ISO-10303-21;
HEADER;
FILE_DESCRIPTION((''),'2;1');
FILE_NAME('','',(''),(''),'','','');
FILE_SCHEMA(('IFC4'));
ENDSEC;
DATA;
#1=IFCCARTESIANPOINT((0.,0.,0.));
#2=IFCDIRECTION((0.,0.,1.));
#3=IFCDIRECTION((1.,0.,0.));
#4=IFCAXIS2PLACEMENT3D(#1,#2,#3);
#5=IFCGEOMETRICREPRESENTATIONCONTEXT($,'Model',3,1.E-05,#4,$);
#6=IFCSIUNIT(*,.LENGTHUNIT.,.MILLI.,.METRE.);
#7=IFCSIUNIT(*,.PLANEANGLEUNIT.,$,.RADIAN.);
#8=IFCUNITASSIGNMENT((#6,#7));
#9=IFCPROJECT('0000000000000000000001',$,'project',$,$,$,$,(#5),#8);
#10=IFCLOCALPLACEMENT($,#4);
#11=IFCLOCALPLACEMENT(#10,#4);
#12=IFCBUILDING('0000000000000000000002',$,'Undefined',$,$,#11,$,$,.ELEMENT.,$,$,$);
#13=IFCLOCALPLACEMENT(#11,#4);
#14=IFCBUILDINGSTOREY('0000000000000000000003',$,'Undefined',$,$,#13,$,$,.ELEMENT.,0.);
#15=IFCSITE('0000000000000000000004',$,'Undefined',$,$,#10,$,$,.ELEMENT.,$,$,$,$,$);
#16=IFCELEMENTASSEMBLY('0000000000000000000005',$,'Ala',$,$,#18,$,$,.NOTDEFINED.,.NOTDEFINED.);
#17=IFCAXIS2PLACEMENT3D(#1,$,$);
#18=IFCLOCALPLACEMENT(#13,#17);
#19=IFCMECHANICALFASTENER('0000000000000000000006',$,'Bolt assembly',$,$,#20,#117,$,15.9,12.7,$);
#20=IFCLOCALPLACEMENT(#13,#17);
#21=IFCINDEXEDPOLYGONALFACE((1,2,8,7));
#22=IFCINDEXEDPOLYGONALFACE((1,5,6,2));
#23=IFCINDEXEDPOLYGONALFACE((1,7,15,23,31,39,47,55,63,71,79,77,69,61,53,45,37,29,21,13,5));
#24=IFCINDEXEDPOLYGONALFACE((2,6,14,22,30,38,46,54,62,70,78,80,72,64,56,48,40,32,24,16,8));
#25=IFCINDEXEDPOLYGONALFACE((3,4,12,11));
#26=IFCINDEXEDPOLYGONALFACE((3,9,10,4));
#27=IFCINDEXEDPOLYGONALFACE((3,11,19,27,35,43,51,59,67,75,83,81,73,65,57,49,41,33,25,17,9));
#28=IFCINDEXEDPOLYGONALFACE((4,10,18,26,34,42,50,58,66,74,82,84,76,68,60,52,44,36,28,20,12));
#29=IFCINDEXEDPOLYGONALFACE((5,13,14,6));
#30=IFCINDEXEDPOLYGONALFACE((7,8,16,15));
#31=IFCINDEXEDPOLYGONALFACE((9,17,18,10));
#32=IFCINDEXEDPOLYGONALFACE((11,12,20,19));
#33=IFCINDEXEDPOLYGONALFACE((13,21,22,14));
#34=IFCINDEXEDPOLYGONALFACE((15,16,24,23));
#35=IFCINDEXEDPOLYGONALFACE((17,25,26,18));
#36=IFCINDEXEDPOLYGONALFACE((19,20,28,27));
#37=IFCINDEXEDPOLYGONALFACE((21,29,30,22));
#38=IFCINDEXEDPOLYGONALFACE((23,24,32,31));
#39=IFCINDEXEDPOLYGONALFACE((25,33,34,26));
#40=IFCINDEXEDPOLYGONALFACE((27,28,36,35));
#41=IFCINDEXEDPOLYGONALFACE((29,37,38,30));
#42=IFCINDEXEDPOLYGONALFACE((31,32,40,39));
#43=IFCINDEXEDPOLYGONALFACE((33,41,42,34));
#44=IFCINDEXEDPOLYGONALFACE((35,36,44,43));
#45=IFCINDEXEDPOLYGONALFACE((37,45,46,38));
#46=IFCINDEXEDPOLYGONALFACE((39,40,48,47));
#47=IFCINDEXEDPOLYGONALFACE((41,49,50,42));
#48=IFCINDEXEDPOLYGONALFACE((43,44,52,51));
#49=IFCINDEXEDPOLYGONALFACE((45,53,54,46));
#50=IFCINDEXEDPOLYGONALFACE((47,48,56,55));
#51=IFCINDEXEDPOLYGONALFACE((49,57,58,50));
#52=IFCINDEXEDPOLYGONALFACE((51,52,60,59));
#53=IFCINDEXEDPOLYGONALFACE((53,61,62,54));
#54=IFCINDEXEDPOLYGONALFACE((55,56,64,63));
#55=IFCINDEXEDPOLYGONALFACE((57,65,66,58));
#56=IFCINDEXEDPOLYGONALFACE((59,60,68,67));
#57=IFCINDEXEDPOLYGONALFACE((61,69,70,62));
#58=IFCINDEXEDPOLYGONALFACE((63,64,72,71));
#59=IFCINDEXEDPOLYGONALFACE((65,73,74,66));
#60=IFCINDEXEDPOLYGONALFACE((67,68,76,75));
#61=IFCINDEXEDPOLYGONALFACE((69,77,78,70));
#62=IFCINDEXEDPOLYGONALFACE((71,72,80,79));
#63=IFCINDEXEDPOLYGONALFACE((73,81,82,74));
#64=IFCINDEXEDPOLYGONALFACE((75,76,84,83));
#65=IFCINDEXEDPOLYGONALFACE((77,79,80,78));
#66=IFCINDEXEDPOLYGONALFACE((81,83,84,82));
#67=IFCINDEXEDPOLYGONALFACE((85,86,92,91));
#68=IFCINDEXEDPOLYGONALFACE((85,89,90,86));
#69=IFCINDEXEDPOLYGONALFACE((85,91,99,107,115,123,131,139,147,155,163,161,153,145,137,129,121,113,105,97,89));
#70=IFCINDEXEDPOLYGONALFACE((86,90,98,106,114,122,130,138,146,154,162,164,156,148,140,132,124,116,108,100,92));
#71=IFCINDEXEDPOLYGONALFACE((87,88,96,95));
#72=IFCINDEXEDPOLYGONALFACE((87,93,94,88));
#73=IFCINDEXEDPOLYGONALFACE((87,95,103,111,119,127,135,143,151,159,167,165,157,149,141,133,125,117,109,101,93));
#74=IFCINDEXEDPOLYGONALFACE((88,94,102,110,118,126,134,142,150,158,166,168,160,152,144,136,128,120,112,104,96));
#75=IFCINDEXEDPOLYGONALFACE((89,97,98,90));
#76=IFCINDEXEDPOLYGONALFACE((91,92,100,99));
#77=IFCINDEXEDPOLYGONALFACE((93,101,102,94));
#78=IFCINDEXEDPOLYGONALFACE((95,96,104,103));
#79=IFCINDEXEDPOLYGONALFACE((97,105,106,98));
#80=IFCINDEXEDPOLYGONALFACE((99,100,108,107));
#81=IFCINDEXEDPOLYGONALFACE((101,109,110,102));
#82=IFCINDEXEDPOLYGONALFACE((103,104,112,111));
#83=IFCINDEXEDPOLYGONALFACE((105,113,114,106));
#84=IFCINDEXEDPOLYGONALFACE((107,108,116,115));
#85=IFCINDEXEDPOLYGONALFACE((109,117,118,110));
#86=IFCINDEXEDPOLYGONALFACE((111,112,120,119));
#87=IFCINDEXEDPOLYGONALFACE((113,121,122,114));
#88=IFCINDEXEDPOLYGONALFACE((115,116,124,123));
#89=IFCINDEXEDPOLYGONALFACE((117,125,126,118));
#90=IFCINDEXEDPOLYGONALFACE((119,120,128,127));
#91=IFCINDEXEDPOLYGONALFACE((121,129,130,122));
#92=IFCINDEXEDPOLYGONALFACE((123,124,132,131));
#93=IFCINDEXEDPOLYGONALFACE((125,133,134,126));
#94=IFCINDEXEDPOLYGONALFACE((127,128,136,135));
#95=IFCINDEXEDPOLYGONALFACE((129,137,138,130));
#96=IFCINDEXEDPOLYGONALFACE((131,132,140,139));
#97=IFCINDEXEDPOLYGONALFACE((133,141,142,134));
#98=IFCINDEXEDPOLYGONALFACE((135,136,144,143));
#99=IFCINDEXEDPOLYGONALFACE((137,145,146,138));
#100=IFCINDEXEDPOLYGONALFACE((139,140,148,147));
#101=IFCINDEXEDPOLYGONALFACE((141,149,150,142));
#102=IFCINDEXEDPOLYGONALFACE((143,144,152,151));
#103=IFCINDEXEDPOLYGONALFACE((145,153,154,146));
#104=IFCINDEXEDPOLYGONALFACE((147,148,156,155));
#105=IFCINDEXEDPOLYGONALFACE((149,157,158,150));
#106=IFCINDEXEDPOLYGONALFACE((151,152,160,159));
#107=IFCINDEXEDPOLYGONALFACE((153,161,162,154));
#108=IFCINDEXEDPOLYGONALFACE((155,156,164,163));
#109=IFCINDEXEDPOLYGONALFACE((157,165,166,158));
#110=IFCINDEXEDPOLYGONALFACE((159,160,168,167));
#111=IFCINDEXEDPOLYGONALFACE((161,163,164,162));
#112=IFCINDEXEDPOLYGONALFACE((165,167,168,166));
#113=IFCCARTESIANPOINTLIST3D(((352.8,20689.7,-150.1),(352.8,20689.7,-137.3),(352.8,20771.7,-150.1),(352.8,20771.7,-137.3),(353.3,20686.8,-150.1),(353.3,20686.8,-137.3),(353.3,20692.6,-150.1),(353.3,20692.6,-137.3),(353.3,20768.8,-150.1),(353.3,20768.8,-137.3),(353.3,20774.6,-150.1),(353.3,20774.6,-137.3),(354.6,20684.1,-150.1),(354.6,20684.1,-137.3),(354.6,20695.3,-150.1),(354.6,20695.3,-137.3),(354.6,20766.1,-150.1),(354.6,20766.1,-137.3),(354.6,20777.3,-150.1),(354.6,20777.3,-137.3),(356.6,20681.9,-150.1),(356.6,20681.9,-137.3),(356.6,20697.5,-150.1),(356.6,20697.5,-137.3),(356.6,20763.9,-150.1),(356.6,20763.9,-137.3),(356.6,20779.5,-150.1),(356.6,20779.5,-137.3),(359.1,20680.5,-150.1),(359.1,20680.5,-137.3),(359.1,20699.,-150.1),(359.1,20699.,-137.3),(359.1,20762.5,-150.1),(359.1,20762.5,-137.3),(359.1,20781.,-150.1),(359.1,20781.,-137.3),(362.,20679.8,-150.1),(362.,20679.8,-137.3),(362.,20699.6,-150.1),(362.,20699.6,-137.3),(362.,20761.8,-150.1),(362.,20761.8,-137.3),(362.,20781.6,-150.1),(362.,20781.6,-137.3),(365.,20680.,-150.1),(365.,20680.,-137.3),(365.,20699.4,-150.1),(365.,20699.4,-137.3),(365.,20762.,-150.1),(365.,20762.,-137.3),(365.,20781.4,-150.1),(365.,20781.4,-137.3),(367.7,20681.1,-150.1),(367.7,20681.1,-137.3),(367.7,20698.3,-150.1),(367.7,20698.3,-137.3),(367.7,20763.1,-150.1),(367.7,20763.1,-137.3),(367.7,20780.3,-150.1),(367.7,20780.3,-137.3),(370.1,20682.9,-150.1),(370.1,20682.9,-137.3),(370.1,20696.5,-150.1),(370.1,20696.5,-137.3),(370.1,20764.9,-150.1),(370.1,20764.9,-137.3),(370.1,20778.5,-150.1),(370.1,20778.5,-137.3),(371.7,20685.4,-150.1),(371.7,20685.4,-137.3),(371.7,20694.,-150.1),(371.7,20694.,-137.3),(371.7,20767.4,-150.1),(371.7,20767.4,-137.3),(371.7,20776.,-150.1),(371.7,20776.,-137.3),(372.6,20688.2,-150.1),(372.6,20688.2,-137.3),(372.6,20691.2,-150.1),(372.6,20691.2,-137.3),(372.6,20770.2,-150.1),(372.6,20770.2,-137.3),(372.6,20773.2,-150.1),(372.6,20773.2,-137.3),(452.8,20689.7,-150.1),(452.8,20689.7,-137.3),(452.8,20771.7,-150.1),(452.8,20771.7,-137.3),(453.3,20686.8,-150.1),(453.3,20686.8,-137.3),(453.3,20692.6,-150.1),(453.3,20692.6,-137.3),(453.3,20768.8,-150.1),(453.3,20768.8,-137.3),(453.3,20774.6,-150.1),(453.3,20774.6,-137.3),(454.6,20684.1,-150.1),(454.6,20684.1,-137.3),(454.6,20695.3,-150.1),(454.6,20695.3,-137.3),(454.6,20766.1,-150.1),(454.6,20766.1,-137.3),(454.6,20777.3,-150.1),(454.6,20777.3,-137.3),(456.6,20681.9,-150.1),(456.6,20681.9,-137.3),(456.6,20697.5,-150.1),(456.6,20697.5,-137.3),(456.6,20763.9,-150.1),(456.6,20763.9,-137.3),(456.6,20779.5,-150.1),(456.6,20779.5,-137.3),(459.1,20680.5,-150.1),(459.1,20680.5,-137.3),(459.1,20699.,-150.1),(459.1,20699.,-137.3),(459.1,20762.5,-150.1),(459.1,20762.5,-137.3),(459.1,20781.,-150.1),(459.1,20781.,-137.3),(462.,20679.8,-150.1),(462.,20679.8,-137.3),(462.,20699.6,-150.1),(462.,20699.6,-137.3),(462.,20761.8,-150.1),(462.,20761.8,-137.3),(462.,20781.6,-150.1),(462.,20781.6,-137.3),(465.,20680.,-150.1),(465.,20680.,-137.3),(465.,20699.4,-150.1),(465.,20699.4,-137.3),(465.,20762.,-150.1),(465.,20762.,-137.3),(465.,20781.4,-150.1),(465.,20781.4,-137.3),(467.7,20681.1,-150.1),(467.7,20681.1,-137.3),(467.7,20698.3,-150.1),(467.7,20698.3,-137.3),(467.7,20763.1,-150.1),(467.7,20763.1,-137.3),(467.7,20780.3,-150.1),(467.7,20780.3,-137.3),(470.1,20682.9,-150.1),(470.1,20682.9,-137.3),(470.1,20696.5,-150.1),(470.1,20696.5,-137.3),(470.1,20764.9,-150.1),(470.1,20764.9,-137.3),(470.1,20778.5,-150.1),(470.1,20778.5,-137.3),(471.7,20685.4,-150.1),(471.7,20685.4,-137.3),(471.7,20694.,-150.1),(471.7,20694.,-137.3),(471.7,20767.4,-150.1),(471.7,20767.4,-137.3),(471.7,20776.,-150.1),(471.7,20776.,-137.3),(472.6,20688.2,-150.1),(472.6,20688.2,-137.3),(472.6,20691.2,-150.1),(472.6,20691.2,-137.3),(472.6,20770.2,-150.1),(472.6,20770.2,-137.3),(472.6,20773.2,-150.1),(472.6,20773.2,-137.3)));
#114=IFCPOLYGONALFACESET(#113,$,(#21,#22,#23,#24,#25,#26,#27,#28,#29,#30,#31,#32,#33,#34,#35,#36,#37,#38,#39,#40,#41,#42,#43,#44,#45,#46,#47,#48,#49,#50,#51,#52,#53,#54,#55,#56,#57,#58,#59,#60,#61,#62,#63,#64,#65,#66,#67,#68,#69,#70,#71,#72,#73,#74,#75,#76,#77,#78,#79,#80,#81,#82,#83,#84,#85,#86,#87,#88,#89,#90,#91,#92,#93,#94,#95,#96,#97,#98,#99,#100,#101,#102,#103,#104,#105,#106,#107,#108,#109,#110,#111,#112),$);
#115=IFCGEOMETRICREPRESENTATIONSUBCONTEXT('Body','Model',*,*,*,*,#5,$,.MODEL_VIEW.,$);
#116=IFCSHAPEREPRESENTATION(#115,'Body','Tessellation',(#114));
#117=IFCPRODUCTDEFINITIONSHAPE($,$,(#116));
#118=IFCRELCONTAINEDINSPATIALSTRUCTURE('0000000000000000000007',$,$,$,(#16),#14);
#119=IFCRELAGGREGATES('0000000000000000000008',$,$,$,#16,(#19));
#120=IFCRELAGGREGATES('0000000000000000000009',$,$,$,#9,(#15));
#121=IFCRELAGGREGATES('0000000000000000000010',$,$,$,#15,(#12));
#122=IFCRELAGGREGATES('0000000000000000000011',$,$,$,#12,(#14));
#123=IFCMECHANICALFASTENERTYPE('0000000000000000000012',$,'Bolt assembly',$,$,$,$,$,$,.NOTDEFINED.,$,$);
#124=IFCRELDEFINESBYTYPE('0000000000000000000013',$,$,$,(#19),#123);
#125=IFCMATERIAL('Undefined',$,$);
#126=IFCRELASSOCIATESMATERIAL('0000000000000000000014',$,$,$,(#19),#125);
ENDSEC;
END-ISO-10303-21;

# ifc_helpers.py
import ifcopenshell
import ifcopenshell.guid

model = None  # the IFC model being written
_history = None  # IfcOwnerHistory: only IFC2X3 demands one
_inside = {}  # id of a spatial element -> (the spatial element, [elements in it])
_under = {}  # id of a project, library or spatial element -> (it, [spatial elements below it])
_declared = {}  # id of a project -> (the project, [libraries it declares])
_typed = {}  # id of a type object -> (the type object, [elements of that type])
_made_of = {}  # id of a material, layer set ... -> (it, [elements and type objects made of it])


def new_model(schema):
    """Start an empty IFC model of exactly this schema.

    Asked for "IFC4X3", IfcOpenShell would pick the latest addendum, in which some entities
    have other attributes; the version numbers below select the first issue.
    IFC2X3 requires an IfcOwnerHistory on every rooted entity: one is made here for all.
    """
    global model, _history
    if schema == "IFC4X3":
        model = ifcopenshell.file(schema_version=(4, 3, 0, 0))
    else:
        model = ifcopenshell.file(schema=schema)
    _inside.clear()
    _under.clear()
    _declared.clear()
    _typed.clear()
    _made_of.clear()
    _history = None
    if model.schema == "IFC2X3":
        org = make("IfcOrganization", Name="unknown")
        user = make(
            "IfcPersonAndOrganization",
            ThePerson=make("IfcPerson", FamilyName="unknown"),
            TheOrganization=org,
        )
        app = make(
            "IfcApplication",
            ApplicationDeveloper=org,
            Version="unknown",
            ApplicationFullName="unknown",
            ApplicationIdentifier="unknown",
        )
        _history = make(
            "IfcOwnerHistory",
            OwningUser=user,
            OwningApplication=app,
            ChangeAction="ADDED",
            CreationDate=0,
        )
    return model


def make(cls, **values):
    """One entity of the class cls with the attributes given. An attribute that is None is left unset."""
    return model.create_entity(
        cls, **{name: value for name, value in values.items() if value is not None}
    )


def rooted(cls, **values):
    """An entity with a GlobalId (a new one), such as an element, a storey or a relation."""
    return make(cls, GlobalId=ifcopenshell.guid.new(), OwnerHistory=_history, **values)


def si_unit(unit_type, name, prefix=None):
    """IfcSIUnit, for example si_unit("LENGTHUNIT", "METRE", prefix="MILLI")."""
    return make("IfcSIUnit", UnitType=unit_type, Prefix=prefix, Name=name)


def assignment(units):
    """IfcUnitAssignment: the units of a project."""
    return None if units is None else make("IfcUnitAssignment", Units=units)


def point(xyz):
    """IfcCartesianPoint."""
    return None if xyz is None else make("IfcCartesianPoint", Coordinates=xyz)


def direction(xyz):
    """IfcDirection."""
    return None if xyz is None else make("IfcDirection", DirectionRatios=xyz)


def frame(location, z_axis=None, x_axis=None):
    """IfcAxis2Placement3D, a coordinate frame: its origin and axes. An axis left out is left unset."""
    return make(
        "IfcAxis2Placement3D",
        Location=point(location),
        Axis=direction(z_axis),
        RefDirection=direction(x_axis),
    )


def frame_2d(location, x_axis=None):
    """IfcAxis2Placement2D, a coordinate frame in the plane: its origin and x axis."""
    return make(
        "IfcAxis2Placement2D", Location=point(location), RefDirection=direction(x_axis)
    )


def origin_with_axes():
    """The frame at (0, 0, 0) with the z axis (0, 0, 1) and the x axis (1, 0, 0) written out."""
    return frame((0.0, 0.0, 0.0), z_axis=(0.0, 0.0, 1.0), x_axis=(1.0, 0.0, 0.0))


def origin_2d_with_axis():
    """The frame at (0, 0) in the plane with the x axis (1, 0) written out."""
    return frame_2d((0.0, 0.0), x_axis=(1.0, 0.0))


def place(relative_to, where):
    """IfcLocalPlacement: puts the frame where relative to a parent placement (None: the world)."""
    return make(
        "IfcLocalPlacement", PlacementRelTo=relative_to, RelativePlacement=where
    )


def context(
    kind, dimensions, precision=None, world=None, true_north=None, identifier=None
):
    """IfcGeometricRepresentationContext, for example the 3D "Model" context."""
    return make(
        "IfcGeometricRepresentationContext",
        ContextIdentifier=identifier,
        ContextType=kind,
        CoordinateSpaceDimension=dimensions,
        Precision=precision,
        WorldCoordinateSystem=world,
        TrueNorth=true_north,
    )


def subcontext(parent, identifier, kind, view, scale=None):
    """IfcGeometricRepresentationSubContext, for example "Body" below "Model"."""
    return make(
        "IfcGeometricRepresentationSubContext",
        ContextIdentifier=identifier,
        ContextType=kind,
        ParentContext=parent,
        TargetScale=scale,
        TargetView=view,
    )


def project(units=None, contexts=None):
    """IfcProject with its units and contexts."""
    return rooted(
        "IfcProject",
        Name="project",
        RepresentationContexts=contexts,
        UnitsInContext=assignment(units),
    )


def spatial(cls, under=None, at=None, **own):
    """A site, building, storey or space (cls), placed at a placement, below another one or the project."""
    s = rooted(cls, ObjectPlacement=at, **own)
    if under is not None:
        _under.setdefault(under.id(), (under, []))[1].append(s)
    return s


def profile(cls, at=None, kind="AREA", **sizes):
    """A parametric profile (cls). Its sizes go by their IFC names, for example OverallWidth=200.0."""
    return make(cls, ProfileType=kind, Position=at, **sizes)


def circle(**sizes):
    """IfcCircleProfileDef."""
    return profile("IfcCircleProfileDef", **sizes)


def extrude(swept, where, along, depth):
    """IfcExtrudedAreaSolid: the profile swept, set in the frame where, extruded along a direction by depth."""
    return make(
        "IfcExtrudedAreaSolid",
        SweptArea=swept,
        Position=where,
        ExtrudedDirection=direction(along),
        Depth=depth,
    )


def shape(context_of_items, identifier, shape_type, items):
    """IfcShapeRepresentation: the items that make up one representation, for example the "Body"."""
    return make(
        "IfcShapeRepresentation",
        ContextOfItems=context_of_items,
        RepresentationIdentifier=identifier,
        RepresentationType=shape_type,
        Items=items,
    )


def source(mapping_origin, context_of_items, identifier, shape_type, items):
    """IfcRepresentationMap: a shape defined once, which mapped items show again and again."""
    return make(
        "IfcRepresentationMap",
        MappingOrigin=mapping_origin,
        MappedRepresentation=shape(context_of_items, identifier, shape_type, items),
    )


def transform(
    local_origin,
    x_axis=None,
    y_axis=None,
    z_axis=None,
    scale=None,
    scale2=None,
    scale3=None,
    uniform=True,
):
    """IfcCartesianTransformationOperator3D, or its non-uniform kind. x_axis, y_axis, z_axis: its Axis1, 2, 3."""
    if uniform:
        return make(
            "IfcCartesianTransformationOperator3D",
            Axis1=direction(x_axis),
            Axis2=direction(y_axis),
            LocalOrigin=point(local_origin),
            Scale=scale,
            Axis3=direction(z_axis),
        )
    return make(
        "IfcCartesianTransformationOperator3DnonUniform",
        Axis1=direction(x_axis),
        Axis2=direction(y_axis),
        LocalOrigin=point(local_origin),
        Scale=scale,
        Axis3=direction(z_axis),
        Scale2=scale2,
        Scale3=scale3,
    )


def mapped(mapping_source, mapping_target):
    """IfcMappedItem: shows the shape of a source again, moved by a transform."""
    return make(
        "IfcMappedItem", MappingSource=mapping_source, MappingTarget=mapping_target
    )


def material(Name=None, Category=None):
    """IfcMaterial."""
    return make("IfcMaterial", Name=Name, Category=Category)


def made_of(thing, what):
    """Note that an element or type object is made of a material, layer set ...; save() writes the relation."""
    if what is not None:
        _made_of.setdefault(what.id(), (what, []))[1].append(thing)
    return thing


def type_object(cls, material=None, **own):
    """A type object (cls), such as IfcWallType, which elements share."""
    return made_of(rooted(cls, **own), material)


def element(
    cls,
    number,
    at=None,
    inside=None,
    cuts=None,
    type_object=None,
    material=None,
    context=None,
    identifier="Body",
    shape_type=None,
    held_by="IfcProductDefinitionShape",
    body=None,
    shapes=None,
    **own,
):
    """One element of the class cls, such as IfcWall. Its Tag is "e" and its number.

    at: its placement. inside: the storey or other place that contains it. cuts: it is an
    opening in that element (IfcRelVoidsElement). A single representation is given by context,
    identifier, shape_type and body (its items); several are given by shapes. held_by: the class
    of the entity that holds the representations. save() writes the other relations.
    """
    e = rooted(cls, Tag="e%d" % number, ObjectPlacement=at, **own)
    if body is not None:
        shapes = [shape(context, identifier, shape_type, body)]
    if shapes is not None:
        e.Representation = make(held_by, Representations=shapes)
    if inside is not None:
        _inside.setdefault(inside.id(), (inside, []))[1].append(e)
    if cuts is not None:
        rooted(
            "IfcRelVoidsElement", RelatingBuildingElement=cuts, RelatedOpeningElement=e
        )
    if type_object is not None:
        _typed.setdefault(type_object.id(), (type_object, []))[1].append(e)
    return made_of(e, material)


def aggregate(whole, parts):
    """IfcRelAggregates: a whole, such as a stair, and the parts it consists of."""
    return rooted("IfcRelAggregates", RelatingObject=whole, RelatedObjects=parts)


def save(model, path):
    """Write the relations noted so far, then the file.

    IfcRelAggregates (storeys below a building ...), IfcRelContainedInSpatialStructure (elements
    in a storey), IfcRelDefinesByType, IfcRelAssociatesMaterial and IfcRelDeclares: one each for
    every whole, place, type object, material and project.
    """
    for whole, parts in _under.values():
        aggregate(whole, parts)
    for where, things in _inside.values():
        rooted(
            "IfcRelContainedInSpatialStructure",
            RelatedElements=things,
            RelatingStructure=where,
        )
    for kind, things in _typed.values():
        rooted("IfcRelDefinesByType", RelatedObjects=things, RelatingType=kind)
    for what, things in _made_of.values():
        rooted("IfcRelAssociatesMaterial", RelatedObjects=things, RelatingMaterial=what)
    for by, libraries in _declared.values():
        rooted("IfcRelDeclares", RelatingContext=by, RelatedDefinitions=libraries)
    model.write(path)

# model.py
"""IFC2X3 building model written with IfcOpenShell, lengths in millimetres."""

from ifc_helpers import new_model, si_unit, frame, origin_with_axes, origin_2d_with_axis, place, context, subcontext, project, spatial, circle, extrude, source, transform, mapped, material, type_object, element, aggregate, save


model = new_model("IFC2X3")

# Units and contexts
model_context = context("Model", 3, precision=1e-05, world=origin_with_axes())
body_context = subcontext(model_context, "Body", "Model", "MODEL_VIEW")
ifc_project = project(units=[si_unit("LENGTHUNIT", "METRE", prefix="MILLI"), si_unit("PLANEANGLEUNIT", "RADIAN")], contexts=[model_context])

# Site, building, storey
site_placement = place(None, origin_with_axes())
site = spatial("IfcSite", under=ifc_project, at=site_placement, Name="Undefined", CompositionType="ELEMENT")
building_placement = place(site_placement, origin_with_axes())
building = spatial("IfcBuilding", under=site, at=building_placement, Name="Undefined", CompositionType="ELEMENT")
storey_placement = place(building_placement, origin_with_axes())
storey = spatial("IfcBuildingStorey", under=building, at=storey_placement, Name="Undefined", CompositionType="ELEMENT", Elevation=0.0)

# Element assembly
assembly_1_placement = place(storey_placement, origin_with_axes())
assembly_1 = element("IfcElementAssembly", 1, at=assembly_1_placement, inside=storey, Name="Ala", AssemblyPlace="NOTDEFINED", PredefinedType="NOTDEFINED")

# Mechanical fastener
ifc_material_1 = material(Name="Undefined")
mechanical_fastener_type = type_object("IfcMechanicalFastenerType", Name="Bolt assembly")
shared_shape_1 = source(origin_with_axes(), body_context, "Body", "SweptSolid", [
    extrude(circle(Radius=9.9, at=origin_2d_with_axis()), frame((0.0, 0.0, 0.0), z_axis=(0.0, 1.0, 0.0), x_axis=(1.0, 0.0, 0.0)), (0.0, 0.0, 1.0), 12.8),
])
mechanical_fastener_1_placement = place(assembly_1_placement, frame((462.8, 20730.7, -137.3), z_axis=(0.0, -1.0, 0.0), x_axis=(-1.0, 0.0, 0.0)))
mechanical_fastener_1 = element("IfcMechanicalFastener", 2, at=mechanical_fastener_1_placement, type_object=mechanical_fastener_type, material=ifc_material_1, Name="Bolt assembly", NominalDiameter=15.9, NominalLength=12.7, context=body_context, shape_type="MappedRepresentation", body=[
    mapped(shared_shape_1, transform((0.0, 0.0, -41.0))),
    mapped(shared_shape_1, transform((100.0, 0.0, -41.0))),
    mapped(shared_shape_1, transform((0.0, 0.0, 41.0))),
    mapped(shared_shape_1, transform((100.0, 0.0, 41.0))),
])
aggregate(assembly_1, [mechanical_fastener_1])

save(model, "model.ifc")
